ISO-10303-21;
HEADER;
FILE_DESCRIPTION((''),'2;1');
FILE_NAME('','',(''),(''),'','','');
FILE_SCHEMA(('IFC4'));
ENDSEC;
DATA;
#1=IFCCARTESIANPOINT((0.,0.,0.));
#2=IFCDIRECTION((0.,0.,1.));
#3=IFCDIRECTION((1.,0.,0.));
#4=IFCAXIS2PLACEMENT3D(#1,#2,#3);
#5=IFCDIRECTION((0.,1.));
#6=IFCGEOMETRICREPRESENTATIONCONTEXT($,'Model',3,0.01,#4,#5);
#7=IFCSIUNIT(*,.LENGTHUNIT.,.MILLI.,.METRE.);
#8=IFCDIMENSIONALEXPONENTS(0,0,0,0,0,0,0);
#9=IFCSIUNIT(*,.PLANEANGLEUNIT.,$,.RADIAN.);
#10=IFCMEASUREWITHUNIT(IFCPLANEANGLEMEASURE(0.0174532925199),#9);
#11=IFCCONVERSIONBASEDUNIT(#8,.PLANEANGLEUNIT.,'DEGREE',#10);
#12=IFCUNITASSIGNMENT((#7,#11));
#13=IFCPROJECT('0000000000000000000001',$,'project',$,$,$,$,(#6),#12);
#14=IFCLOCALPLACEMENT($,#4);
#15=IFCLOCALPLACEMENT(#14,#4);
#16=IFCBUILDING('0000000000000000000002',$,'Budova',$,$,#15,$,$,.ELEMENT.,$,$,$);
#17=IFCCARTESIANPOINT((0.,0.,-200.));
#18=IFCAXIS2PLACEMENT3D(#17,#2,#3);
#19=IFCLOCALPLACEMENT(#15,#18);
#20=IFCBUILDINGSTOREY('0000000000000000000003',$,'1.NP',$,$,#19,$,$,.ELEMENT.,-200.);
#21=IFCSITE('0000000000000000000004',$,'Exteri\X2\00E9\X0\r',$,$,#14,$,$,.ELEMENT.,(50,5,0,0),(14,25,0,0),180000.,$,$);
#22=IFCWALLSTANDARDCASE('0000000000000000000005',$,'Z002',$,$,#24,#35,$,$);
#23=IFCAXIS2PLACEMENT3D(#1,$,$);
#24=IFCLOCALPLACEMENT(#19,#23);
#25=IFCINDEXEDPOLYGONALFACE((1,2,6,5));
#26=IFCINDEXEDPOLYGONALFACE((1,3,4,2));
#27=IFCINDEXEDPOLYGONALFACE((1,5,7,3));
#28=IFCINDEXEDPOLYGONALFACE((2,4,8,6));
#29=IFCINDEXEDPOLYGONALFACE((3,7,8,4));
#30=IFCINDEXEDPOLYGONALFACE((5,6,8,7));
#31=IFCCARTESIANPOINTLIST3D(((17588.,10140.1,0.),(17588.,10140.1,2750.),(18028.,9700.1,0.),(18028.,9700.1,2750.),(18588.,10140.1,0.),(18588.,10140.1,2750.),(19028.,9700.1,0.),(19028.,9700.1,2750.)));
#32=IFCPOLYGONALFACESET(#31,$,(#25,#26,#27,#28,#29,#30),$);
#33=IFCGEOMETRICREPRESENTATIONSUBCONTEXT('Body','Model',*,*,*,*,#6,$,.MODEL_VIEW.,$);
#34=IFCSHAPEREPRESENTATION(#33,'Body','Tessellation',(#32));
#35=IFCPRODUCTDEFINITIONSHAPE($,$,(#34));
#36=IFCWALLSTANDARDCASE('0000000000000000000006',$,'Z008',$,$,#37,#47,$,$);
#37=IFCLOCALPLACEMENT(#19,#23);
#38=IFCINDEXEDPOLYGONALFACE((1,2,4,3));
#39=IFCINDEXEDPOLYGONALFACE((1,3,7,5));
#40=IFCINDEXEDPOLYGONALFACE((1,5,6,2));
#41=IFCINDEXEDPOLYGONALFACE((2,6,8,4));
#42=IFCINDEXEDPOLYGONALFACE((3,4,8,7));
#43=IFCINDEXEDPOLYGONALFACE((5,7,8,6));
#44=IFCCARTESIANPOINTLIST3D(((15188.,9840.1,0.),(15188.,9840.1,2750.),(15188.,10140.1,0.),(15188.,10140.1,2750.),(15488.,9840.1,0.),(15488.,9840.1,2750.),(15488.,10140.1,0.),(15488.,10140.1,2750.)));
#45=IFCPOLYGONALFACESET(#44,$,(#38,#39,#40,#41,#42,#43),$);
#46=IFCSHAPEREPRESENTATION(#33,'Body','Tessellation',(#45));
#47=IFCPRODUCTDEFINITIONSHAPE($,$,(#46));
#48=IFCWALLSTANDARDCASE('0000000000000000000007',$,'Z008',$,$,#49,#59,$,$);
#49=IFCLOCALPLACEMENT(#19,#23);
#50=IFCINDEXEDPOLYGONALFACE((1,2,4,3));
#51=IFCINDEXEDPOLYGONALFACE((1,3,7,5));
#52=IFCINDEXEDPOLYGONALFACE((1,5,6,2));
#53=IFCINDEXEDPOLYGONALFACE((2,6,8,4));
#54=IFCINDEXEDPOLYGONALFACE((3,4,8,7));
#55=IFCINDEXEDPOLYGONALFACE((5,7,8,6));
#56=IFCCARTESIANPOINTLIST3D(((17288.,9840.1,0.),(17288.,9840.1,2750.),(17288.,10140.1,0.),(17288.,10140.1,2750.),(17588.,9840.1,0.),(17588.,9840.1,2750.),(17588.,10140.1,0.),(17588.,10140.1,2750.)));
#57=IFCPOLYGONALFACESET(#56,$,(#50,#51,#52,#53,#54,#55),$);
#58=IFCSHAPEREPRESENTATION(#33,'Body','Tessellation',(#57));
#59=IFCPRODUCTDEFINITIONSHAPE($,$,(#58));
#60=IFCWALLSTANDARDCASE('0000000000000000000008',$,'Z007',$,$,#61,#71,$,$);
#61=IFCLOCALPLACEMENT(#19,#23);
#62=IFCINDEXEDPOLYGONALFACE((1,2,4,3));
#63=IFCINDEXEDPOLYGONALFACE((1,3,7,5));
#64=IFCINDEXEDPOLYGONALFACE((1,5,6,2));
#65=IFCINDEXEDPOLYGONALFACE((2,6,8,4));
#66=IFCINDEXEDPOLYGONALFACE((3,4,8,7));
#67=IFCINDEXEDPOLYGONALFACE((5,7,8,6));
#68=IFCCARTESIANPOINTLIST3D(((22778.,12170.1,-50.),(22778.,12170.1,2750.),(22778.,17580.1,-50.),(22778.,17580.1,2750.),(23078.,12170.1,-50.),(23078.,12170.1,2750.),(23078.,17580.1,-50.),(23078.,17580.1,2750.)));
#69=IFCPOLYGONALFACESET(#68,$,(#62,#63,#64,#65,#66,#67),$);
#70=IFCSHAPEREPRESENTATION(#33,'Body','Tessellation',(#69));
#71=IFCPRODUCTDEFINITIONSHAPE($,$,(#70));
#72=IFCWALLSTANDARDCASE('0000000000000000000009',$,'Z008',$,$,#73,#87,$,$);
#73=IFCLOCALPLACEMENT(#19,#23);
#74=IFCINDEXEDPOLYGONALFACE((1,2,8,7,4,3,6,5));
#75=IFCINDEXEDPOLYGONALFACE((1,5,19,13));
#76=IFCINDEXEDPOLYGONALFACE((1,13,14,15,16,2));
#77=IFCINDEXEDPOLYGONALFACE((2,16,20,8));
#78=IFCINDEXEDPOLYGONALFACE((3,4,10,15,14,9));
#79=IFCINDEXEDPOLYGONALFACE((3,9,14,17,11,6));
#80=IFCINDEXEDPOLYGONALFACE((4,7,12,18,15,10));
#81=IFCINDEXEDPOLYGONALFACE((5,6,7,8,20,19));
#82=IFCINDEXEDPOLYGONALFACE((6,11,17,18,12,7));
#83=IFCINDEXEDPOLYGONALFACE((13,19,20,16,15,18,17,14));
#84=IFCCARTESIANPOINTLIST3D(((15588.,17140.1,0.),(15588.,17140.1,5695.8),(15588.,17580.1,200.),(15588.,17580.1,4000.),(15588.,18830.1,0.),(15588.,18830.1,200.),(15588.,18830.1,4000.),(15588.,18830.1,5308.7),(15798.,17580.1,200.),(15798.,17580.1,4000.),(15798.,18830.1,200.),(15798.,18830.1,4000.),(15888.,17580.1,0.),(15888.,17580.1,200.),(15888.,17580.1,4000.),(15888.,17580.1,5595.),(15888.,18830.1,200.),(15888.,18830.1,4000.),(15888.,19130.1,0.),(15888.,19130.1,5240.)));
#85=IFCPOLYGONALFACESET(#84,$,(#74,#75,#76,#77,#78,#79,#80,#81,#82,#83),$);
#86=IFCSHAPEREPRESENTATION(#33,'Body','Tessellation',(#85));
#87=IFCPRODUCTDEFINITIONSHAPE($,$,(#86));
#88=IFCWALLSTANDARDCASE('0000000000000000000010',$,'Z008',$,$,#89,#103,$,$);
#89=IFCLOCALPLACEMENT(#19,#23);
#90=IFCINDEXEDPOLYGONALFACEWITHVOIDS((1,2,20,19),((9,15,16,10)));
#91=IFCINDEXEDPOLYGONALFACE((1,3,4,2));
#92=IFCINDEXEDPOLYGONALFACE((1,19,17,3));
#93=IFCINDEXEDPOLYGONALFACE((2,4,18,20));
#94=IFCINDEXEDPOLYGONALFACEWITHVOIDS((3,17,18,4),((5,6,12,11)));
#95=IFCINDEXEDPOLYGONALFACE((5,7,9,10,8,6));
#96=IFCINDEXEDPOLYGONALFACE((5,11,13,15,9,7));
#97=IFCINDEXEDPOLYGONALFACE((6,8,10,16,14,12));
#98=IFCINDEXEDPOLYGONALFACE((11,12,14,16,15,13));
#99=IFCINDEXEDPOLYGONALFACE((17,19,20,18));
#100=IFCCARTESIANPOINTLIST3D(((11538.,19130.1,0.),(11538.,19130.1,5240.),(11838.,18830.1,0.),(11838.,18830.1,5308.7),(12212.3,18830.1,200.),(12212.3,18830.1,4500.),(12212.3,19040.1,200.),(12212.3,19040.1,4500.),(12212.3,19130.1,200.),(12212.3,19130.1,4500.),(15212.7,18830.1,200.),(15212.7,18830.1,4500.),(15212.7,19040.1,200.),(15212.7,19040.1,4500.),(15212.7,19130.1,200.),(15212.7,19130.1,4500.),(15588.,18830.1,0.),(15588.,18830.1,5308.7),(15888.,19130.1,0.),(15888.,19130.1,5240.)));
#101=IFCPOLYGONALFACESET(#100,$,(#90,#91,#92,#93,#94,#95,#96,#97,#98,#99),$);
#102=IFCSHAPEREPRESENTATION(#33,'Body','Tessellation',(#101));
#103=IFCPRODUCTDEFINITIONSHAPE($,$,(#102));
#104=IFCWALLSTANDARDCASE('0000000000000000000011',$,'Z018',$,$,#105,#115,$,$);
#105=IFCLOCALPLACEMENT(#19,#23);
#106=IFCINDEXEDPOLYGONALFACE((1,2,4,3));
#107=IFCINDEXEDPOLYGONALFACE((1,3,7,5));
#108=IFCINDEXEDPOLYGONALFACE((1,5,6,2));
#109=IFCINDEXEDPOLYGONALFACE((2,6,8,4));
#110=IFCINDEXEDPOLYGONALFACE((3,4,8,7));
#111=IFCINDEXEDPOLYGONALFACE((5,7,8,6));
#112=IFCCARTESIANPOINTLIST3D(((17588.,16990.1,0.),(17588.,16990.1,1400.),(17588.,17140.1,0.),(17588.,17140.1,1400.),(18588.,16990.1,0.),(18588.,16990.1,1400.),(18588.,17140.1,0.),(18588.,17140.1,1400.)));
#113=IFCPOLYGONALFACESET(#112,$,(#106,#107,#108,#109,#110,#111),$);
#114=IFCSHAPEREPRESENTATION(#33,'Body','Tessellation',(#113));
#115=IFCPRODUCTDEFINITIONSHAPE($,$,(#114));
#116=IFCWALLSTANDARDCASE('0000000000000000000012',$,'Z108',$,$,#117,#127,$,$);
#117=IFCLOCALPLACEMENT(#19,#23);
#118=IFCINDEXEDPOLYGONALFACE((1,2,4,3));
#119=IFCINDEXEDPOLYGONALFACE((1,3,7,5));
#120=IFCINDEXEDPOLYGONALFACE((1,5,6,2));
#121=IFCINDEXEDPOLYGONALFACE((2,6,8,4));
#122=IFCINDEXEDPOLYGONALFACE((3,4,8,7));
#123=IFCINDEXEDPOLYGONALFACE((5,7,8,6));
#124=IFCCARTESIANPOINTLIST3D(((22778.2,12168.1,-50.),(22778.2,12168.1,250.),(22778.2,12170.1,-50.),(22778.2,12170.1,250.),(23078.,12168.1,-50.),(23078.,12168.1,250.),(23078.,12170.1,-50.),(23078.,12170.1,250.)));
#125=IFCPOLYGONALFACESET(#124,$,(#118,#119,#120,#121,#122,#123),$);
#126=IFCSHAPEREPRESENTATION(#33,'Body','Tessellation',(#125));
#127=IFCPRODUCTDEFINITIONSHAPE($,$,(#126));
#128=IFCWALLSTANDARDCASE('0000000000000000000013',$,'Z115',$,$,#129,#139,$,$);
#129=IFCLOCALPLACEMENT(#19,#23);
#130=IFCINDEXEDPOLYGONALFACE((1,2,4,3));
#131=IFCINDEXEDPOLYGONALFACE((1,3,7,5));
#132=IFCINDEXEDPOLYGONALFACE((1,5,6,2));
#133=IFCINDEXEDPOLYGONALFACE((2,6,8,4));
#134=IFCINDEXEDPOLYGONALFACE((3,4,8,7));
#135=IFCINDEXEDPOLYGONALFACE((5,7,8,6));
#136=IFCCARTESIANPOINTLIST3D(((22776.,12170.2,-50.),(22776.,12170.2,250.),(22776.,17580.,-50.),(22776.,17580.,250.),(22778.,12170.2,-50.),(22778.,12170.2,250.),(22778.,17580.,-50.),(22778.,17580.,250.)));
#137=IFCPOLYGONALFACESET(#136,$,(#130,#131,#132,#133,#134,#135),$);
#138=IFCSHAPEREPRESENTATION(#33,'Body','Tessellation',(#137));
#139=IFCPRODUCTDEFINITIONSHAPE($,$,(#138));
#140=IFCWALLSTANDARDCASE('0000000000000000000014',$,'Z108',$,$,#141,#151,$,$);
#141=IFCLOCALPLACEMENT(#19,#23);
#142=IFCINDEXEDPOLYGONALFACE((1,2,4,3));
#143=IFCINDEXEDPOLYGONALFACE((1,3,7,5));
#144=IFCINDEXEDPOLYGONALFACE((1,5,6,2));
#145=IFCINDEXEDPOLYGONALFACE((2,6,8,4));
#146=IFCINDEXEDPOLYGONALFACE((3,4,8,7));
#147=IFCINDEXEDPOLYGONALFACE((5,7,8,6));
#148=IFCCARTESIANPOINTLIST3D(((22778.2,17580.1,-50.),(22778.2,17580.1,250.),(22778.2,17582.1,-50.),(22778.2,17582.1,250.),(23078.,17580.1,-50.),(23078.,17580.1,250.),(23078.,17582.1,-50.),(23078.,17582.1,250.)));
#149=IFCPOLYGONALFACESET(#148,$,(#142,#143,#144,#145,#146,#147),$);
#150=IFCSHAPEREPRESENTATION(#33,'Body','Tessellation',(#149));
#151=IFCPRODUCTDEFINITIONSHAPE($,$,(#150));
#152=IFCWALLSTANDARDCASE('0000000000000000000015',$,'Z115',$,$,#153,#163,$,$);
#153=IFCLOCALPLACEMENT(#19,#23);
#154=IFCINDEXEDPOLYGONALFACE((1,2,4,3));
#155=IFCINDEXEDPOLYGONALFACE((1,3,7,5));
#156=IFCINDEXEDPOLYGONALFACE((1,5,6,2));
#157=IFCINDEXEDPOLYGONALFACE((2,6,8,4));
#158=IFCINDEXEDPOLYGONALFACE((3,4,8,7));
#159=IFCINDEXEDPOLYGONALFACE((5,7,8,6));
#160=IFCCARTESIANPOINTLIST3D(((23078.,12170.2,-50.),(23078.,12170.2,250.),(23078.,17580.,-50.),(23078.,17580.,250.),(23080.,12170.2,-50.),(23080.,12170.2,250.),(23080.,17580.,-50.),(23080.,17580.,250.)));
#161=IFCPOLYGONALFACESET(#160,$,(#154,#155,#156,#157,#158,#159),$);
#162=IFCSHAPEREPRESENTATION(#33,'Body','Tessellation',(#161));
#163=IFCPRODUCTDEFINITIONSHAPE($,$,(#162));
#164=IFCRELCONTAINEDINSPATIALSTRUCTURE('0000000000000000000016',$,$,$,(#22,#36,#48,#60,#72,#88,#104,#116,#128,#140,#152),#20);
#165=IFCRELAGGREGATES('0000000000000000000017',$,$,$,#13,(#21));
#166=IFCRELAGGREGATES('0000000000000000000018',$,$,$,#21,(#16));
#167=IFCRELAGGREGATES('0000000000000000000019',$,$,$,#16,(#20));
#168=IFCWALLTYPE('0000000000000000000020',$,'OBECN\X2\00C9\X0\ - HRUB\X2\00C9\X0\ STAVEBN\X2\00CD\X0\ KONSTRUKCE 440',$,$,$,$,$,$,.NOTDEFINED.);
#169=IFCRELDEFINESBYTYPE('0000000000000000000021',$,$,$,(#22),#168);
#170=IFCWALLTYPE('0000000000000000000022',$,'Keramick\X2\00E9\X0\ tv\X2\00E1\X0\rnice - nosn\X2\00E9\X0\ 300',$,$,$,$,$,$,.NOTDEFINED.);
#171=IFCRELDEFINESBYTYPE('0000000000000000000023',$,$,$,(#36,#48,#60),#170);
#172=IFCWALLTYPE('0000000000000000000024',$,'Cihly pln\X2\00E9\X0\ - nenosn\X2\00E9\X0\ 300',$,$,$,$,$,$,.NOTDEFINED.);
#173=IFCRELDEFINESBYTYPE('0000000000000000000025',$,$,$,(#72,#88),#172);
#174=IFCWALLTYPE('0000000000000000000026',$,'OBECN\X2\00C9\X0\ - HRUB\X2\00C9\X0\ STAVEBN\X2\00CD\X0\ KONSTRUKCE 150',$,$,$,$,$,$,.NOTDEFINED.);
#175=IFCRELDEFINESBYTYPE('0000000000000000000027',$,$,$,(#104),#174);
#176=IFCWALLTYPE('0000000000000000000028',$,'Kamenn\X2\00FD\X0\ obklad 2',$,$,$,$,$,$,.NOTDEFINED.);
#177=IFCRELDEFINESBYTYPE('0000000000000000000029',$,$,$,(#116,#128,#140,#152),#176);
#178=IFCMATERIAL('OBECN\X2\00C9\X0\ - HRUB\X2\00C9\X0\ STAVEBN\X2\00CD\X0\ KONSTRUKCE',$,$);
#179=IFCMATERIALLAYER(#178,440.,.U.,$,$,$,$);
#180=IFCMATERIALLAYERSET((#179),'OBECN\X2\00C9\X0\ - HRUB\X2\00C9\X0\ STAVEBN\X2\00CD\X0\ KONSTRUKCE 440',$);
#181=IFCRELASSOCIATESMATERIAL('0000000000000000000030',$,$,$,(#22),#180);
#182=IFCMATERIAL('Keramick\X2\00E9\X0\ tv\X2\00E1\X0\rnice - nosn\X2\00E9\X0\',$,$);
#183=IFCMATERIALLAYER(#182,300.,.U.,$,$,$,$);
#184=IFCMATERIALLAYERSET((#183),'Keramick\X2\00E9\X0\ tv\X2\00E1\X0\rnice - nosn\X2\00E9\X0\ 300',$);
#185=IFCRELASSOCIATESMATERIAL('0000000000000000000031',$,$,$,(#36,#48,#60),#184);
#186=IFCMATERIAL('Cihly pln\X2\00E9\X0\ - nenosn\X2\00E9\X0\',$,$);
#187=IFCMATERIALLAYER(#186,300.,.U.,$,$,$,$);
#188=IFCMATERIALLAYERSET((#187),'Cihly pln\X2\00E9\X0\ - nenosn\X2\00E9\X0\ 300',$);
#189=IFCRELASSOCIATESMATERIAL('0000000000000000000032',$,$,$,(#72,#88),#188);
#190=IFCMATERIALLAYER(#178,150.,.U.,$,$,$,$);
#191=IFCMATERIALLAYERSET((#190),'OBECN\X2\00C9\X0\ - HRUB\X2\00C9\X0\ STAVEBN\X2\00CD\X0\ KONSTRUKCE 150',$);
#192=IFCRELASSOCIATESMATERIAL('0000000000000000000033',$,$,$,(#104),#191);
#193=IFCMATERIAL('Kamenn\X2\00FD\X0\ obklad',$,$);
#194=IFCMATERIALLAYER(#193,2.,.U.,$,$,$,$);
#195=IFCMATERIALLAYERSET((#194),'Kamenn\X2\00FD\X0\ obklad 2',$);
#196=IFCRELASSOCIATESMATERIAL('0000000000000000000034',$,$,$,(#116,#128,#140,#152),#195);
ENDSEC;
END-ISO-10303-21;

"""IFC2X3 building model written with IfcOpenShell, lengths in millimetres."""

from ifc_helpers import new_model, entity, si_unit, converted_unit, direction, frame, origin_with_axes, origin_2d_with_axis, place, context, subcontext, project, spatial, polyline, rectangle, outline, extrude, clip, halfspace, material, layer, layer_set, layer_usage, type_object, element, save


model = new_model("IFC2X3")

# Units and contexts
model_context = context("Model", 3, precision=0.01, world=origin_with_axes(), true_north=direction((0.0, 1.0)))
body_context = subcontext(model_context, "Body", "Model", "MODEL_VIEW")
ifc_project = project(units=[si_unit("LENGTHUNIT", "METRE", prefix="MILLI"), converted_unit("PLANEANGLEUNIT", "DEGREE", entity("IfcPlaneAngleMeasure", 0.0174532925199), si_unit("PLANEANGLEUNIT", "RADIAN"), dimensions=[0, 0, 0, 0, 0, 0, 0])], contexts=[model_context])

# Site, building, storey
site_placement = place(None, origin_with_axes())
site = spatial("IfcSite", under=ifc_project, at=site_placement, Name="Exteriér", CompositionType="ELEMENT", RefLatitude=(50, 5, 0, 0), RefLongitude=(14, 25, 0, 0), RefElevation=180000.0)
building_placement = place(site_placement, origin_with_axes())
building = spatial("IfcBuilding", under=site, at=building_placement, Name="Budova", CompositionType="ELEMENT")
storey_placement = place(building_placement, frame((0.0, 0.0, -200.0), z_axis=(0.0, 0.0, 1.0), x_axis=(1.0, 0.0, 0.0)))
storey = spatial("IfcBuildingStorey", under=building, at=storey_placement, Name="1.NP", CompositionType="ELEMENT", Elevation=-200.0)

# Shared definitions
ifc_material_1 = material(Name="OBECNÉ - HRUBÉ STAVEBNÍ KONSTRUKCE")
ifc_layer_1 = layer(ifc_material_1, 440.0, ventilated="UNKNOWN")
ifc_layer_set_1 = layer_set([ifc_layer_1], Name="OBECNÉ - HRUBÉ STAVEBNÍ KONSTRUKCE 440")
wall_type_1 = type_object("IfcWallType", Name="OBECNÉ - HRUBÉ STAVEBNÍ KONSTRUKCE 440", PredefinedType="NOTDEFINED")

# Wall
ifc_layer_usage_1 = layer_usage(ifc_layer_set_1, "AXIS2", "POSITIVE", -440.0)
wall_1_placement = place(storey_placement, frame((19028.0, 9700.1, 0.0), z_axis=(0.0, 0.0, 1.0), x_axis=(-1.0, 0.0, 0.0)))
element("IfcWallStandardCase", 1, at=wall_1_placement, inside=storey, type_object=wall_type_1, material=ifc_layer_usage_1, Name="Z002", context=body_context, shape_type="SweptSolid", body=[
    extrude(outline(polyline([(440.0, -440.0), (1440.0, -440.0), (1000.0, 0.0), (0.0, 0.0), (440.0, -440.0)])), origin_with_axes(), (0.0, 0.0, 1.0), 2750.0),
])

# Shared definitions
ifc_material_2 = material(Name="Keramické tvárnice - nosné")
ifc_layer_2 = layer(ifc_material_2, 300.0, ventilated="UNKNOWN")
ifc_layer_set_2 = layer_set([ifc_layer_2], Name="Keramické tvárnice - nosné 300")
wall_type_2 = type_object("IfcWallType", Name="Keramické tvárnice - nosné 300", PredefinedType="NOTDEFINED")

# Walls
ifc_layer_usage_2 = layer_usage(ifc_layer_set_2, "AXIS2", "POSITIVE", -300.0)
wall_2_placement = place(storey_placement, frame((15188.0, 10140.1, 0.0), z_axis=(0.0, 0.0, 1.0), x_axis=(1.0, 0.0, 0.0)))
element("IfcWallStandardCase", 2, at=wall_2_placement, inside=storey, type_object=wall_type_2, material=ifc_layer_usage_2, Name="Z008", context=body_context, shape_type="SweptSolid", body=[
    extrude(outline(polyline([(0.0, -300.0), (300.0, -300.0), (300.0, 0.0), (0.0, 0.0), (0.0, -300.0)])), origin_with_axes(), (0.0, 0.0, 1.0), 2750.0),
])
ifc_layer_usage_3 = layer_usage(ifc_layer_set_2, "AXIS2", "NEGATIVE", 300.0)
wall_3_placement = place(storey_placement, frame((17588.0, 10140.1, 0.0), z_axis=(0.0, 0.0, 1.0), x_axis=(-1.0, 0.0, 0.0)))
element("IfcWallStandardCase", 3, at=wall_3_placement, inside=storey, type_object=wall_type_2, material=ifc_layer_usage_3, Name="Z008", context=body_context, shape_type="SweptSolid", body=[
    extrude(outline(polyline([(0.0, 0.0), (300.0, 0.0), (300.0, 300.0), (0.0, 300.0), (0.0, 0.0)])), origin_with_axes(), (0.0, 0.0, 1.0), 2750.0),
])

# Wall
ifc_layer_usage_4 = layer_usage(ifc_layer_set_2, "AXIS2", "POSITIVE", 0.0)
wall_4_placement = place(storey_placement, frame((23078.0, 12170.1, -50.0), z_axis=(0.0, 0.0, 1.0), x_axis=(0.0, 1.0, 0.0)))
element("IfcWallStandardCase", 4, at=wall_4_placement, inside=storey, type_object=wall_type_2, material=ifc_layer_usage_4, Name="Z007", context=body_context, shape_type="SweptSolid", body=[
    extrude(outline(polyline([(0.0, 0.0), (5410.0, 0.0), (5410.0, 300.0), (0.0, 300.0), (0.0, 0.0)])), origin_with_axes(), (0.0, 0.0, 1.0), 2800.0),
])

# Walls, openings
ifc_material_3 = material(Name="Cihly plné - nenosné")
ifc_layer_3 = layer(ifc_material_3, 300.0, ventilated="UNKNOWN")
ifc_layer_set_3 = layer_set([ifc_layer_3], Name="Cihly plné - nenosné 300")
ifc_layer_usage_5 = layer_usage(ifc_layer_set_3, "AXIS2", "NEGATIVE", 0.0)
wall_type_3 = type_object("IfcWallType", Name="Cihly plné - nenosné 300", PredefinedType="NOTDEFINED")
wall_5_placement = place(storey_placement, frame((15888.0, 19130.1, 0.0), z_axis=(0.0, 0.0, 1.0), x_axis=(0.0, -1.0, 0.0)))
wall_5 = element("IfcWallStandardCase", 5, at=wall_5_placement, inside=storey, type_object=wall_type_3, material=ifc_layer_usage_5, Name="Z008", context=body_context, shape_type="Clipping", body=[
    clip(extrude(outline(polyline([(300.0, -300.0), (1990.0, -300.0), (1550.0, 0.0), (0.0, 0.0), (300.0, -300.0)])), origin_with_axes(), (0.0, 0.0, 1.0), 8000.0), halfspace(frame((-1140.3, 0.0, 4978.9), z_axis=(0.22325, 0.0, -0.974761), x_axis=(0.0, 1.0, 0.0)), True)),
])
opening_1_placement = place(wall_5_placement, frame((925.0, 0.0, 200.0), z_axis=(0.0, 0.0, 1.0), x_axis=(1.0, 0.0, 0.0)))
element("IfcOpeningElement", 6, at=opening_1_placement, cuts=wall_5, context=body_context, shape_type="SweptSolid", body=[
    extrude(rectangle(XDim=1250.0, YDim=3800.0, at=origin_2d_with_axis()), frame((0.0, -90.0, 1900.0), z_axis=(0.0, 1.0, 0.0), x_axis=(-1.0, 0.0, 0.0)), (0.0, 0.0, -1.0), 510.0),
    extrude(rectangle(XDim=1250.0, YDim=3800.0, at=origin_2d_with_axis()), frame((0.0, -90.0, 1900.0), z_axis=(0.0, -1.0, 0.0), x_axis=(-1.0, 0.0, 0.0)), (0.0, 0.0, -1.0), 390.0),
])
ifc_layer_usage_6 = layer_usage(ifc_layer_set_3, "AXIS2", "POSITIVE", 0.0)
wall_6_placement = place(storey_placement, frame((15888.0, 19130.1, 0.0), z_axis=(0.0, 0.0, 1.0), x_axis=(-1.0, 0.0, 0.0)))
wall_6 = element("IfcWallStandardCase", 7, at=wall_6_placement, inside=storey, type_object=wall_type_3, material=ifc_layer_usage_6, Name="Z008", context=body_context, shape_type="Clipping", body=[
    clip(extrude(outline(polyline([(0.0, 0.0), (4350.0, 0.0), (4050.0, 300.0), (300.0, 300.0), (0.0, 0.0)])), origin_with_axes(), (0.0, 0.0, 1.0), 7000.0), halfspace(frame((0.0, -1140.3, 4978.9), z_axis=(0.0, 0.22325, -0.974761), x_axis=(0.0, 0.974761, 0.22325)), True)),
])
opening_2_placement = place(wall_6_placement, frame((2175.5, 0.0, 200.0), z_axis=(0.0, 0.0, 1.0), x_axis=(1.0, 0.0, 0.0)))
element("IfcOpeningElement", 8, at=opening_2_placement, cuts=wall_6, context=body_context, shape_type="SweptSolid", body=[
    extrude(rectangle(XDim=3000.4, YDim=4300.0, at=origin_2d_with_axis()), frame((0.0, 90.0, 2150.0), z_axis=(0.0, 1.0, 0.0), x_axis=(-1.0, 0.0, 0.0)), (0.0, 0.0, 1.0), 510.0),
    extrude(rectangle(XDim=3000.4, YDim=4300.0, at=origin_2d_with_axis()), frame((0.0, 90.0, 2150.0), z_axis=(0.0, -1.0, 0.0), x_axis=(-1.0, 0.0, 0.0)), (0.0, 0.0, 1.0), 390.0),
])

# Walls
ifc_layer_4 = layer(ifc_material_1, 150.0, ventilated="UNKNOWN")
ifc_layer_set_4 = layer_set([ifc_layer_4], Name="OBECNÉ - HRUBÉ STAVEBNÍ KONSTRUKCE 150")
ifc_layer_usage_7 = layer_usage(ifc_layer_set_4, "AXIS2", "POSITIVE", 0.0)
wall_type_4 = type_object("IfcWallType", Name="OBECNÉ - HRUBÉ STAVEBNÍ KONSTRUKCE 150", PredefinedType="NOTDEFINED")
wall_7_placement = place(storey_placement, frame((18588.0, 17140.1, 0.0), z_axis=(0.0, 0.0, 1.0), x_axis=(-1.0, 0.0, 0.0)))
element("IfcWallStandardCase", 9, at=wall_7_placement, inside=storey, type_object=wall_type_4, material=ifc_layer_usage_7, Name="Z018", context=body_context, shape_type="SweptSolid", body=[
    extrude(outline(polyline([(0.0, 0.0), (1000.0, 0.0), (1000.0, 150.0), (0.0, 150.0), (0.0, 0.0)])), origin_with_axes(), (0.0, 0.0, 1.0), 1400.0),
])
ifc_material_4 = material(Name="Kamenný obklad")
ifc_layer_5 = layer(ifc_material_4, 2.0, ventilated="UNKNOWN")
ifc_layer_set_5 = layer_set([ifc_layer_5], Name="Kamenný obklad 2")
ifc_layer_usage_8 = layer_usage(ifc_layer_set_5, "AXIS2", "NEGATIVE", 2.0)
wall_type_5 = type_object("IfcWallType", Name="Kamenný obklad 2", PredefinedType="NOTDEFINED")
wall_8_placement = place(storey_placement, frame((23078.0, 12170.1, -50.0), z_axis=(0.0, 0.0, 1.0), x_axis=(-1.0, 0.0, 0.0)))
element("IfcWallStandardCase", 10, at=wall_8_placement, inside=storey, type_object=wall_type_5, material=ifc_layer_usage_8, Name="Z108", context=body_context, shape_type="SweptSolid", body=[
    extrude(outline(polyline([(0.0, 0.0), (299.7, 0.0), (299.7, 2.0), (0.0, 2.0), (0.0, 0.0)])), origin_with_axes(), (0.0, 0.0, 1.0), 300.0),
])
ifc_layer_usage_9 = layer_usage(ifc_layer_set_5, "AXIS2", "NEGATIVE", 2.0)
wall_9_placement = place(storey_placement, frame((22778.0, 12170.2, -50.0), z_axis=(0.0, 0.0, 1.0), x_axis=(0.0, 1.0, 0.0)))
element("IfcWallStandardCase", 11, at=wall_9_placement, inside=storey, type_object=wall_type_5, material=ifc_layer_usage_9, Name="Z115", context=body_context, shape_type="SweptSolid", body=[
    extrude(outline(polyline([(0.0, 0.0), (5409.8, 0.0), (5409.8, 2.0), (0.0, 2.0), (0.0, 0.0)])), origin_with_axes(), (0.0, 0.0, 1.0), 300.0),
])
ifc_layer_usage_10 = layer_usage(ifc_layer_set_5, "AXIS2", "POSITIVE", -2.0)
wall_10_placement = place(storey_placement, frame((23078.0, 17580.1, -50.0), z_axis=(0.0, 0.0, 1.0), x_axis=(-1.0, 0.0, 0.0)))
element("IfcWallStandardCase", 12, at=wall_10_placement, inside=storey, type_object=wall_type_5, material=ifc_layer_usage_10, Name="Z108", context=body_context, shape_type="SweptSolid", body=[
    extrude(outline(polyline([(0.0, -2.0), (299.7, -2.0), (299.7, 0.0), (0.0, 0.0), (0.0, -2.0)])), origin_with_axes(), (0.0, 0.0, 1.0), 300.0),
])
ifc_layer_usage_11 = layer_usage(ifc_layer_set_5, "AXIS2", "POSITIVE", -2.0)
wall_11_placement = place(storey_placement, frame((23078.0, 12170.2, -50.0), z_axis=(0.0, 0.0, 1.0), x_axis=(0.0, 1.0, 0.0)))
element("IfcWallStandardCase", 13, at=wall_11_placement, inside=storey, type_object=wall_type_5, material=ifc_layer_usage_11, Name="Z115", context=body_context, shape_type="SweptSolid", body=[
    extrude(outline(polyline([(0.0, -2.0), (5409.8, -2.0), (5409.8, 0.0), (0.0, 0.0), (0.0, -2.0)])), origin_with_axes(), (0.0, 0.0, 1.0), 300.0),
])

save(model, "model.ifc")
